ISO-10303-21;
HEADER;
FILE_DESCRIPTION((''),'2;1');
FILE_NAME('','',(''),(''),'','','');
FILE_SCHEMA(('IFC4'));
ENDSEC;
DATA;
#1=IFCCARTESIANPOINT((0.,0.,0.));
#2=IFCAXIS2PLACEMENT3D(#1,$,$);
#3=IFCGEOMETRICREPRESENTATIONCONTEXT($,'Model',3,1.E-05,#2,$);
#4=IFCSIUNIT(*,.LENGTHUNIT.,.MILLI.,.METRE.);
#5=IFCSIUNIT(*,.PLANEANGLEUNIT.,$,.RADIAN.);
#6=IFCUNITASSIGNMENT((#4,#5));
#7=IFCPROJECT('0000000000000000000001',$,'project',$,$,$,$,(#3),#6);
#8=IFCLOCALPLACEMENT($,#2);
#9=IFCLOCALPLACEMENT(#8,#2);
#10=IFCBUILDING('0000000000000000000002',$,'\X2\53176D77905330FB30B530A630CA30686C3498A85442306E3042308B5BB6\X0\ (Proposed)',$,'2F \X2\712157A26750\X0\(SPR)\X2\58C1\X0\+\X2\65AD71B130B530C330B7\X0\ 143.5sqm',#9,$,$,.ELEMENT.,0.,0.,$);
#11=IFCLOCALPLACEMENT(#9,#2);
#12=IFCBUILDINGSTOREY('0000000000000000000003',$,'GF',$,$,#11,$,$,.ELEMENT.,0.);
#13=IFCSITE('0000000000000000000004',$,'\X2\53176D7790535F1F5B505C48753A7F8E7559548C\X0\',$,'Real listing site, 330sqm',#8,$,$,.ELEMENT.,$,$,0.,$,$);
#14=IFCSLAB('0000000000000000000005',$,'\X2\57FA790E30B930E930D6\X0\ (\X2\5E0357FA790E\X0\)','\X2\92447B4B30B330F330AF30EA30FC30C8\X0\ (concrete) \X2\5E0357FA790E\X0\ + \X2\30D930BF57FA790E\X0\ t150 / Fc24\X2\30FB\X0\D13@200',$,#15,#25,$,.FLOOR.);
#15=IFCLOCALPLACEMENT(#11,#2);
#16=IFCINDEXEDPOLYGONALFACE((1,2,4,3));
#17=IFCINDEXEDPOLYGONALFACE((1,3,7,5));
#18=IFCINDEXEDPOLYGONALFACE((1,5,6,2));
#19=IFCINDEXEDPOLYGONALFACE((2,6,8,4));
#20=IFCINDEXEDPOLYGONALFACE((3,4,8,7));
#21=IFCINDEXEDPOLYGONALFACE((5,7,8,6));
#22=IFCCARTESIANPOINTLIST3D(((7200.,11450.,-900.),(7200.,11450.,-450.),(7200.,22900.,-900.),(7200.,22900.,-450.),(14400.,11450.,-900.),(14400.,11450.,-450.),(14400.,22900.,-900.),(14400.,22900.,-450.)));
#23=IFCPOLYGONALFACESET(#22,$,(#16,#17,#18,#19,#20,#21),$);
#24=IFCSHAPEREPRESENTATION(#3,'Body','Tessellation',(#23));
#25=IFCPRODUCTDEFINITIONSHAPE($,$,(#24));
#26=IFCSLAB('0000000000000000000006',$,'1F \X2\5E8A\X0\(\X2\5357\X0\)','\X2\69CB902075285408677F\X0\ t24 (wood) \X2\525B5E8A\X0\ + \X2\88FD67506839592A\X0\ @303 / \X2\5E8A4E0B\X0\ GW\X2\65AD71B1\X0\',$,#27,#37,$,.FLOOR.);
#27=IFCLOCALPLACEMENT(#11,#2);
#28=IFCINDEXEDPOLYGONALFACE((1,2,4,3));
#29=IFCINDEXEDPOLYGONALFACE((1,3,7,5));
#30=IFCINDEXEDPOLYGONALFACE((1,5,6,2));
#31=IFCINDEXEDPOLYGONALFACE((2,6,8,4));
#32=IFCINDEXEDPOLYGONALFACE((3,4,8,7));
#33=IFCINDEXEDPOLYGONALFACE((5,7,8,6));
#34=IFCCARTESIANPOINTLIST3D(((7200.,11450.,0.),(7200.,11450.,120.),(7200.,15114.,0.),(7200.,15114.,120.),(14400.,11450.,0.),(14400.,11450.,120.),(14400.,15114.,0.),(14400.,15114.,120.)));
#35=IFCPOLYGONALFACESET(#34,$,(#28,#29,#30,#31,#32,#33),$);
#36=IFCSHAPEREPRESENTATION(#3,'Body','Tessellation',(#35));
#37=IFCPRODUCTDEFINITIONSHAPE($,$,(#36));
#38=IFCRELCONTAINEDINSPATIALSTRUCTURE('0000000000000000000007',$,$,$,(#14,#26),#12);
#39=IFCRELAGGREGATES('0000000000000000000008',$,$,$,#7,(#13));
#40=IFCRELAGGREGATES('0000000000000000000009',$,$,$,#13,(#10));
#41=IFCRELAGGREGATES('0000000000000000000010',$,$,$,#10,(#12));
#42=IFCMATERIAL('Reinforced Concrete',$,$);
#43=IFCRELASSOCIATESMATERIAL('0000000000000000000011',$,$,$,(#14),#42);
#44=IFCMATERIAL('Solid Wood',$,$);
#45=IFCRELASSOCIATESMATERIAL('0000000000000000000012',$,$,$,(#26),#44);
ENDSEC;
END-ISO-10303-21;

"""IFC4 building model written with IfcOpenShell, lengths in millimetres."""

from ifc_helpers import new_model, si_unit, frame, frame_2d, origin, place, context, project, spatial, rectangle, extrude, material, element, save


model = new_model("IFC4")

# Units and contexts
model_context = context("Model", 3, precision=1e-05, world=origin())
ifc_project = project(units=[si_unit("LENGTHUNIT", "METRE", prefix="MILLI"), si_unit("PLANEANGLEUNIT", "RADIAN")], contexts=[model_context])

# Site, building, storey
site_placement = place(None, origin())
site = spatial("IfcSite", under=ifc_project, at=site_placement, Name="北海道弟子屈町美留和", ObjectType="Real listing site, 330sqm", CompositionType="ELEMENT", RefElevation=0.0)
building_placement = place(site_placement, origin())
building = spatial("IfcBuilding", under=site, at=building_placement, Name="北海道・サウナと水風呂のある家 (Proposed)", ObjectType="2F 無垢材(SPR)壁+断熱サッシ 143.5sqm", CompositionType="ELEMENT", ElevationOfRefHeight=0.0, ElevationOfTerrain=0.0)
storey_placement = place(building_placement, origin())
storey = spatial("IfcBuildingStorey", under=building, at=storey_placement, Name="GF", CompositionType="ELEMENT", Elevation=0.0)

# Shared definitions
ifc_material_1 = material(Name="Solid Wood")

# Slabs
ifc_material_2 = material(Name="Reinforced Concrete")
slab_1_placement = place(storey_placement, frame((3600.0, 5725.0, -450.0)))
element("IfcSlab", 1, at=slab_1_placement, inside=storey, material=ifc_material_2, Name="基礎スラブ (布基礎)", Description="鉄筋コンクリート (concrete) 布基礎 + ベタ基礎 t150 / Fc24・D13@200", PredefinedType="FLOOR", context=model_context, shape_type="SweptSolid", body=[
    extrude(rectangle(XDim=7200.0, YDim=11450.0, at=frame_2d((3600.0, 5725.0))), frame((3600.0, 5725.0, -450.0)), (0.0, 0.0, 1.0), 450.0),
])
slab_2_placement = place(storey_placement, frame((3600.0, 5725.0, 0.0)))
element("IfcSlab", 2, at=slab_2_placement, inside=storey, material=ifc_material_1, Name="1F 床(南)", Description="構造用合板 t24 (wood) 剛床 + 製材根太 @303 / 床下 GW断熱", PredefinedType="FLOOR", context=model_context, shape_type="SweptSolid", body=[
    extrude(rectangle(XDim=7200.0, YDim=3664.0, at=frame_2d((3600.0, 1832.0))), frame((3600.0, 5725.0, 0.0)), (0.0, 0.0, 1.0), 120.0),
])

save(model, "model.ifc")
